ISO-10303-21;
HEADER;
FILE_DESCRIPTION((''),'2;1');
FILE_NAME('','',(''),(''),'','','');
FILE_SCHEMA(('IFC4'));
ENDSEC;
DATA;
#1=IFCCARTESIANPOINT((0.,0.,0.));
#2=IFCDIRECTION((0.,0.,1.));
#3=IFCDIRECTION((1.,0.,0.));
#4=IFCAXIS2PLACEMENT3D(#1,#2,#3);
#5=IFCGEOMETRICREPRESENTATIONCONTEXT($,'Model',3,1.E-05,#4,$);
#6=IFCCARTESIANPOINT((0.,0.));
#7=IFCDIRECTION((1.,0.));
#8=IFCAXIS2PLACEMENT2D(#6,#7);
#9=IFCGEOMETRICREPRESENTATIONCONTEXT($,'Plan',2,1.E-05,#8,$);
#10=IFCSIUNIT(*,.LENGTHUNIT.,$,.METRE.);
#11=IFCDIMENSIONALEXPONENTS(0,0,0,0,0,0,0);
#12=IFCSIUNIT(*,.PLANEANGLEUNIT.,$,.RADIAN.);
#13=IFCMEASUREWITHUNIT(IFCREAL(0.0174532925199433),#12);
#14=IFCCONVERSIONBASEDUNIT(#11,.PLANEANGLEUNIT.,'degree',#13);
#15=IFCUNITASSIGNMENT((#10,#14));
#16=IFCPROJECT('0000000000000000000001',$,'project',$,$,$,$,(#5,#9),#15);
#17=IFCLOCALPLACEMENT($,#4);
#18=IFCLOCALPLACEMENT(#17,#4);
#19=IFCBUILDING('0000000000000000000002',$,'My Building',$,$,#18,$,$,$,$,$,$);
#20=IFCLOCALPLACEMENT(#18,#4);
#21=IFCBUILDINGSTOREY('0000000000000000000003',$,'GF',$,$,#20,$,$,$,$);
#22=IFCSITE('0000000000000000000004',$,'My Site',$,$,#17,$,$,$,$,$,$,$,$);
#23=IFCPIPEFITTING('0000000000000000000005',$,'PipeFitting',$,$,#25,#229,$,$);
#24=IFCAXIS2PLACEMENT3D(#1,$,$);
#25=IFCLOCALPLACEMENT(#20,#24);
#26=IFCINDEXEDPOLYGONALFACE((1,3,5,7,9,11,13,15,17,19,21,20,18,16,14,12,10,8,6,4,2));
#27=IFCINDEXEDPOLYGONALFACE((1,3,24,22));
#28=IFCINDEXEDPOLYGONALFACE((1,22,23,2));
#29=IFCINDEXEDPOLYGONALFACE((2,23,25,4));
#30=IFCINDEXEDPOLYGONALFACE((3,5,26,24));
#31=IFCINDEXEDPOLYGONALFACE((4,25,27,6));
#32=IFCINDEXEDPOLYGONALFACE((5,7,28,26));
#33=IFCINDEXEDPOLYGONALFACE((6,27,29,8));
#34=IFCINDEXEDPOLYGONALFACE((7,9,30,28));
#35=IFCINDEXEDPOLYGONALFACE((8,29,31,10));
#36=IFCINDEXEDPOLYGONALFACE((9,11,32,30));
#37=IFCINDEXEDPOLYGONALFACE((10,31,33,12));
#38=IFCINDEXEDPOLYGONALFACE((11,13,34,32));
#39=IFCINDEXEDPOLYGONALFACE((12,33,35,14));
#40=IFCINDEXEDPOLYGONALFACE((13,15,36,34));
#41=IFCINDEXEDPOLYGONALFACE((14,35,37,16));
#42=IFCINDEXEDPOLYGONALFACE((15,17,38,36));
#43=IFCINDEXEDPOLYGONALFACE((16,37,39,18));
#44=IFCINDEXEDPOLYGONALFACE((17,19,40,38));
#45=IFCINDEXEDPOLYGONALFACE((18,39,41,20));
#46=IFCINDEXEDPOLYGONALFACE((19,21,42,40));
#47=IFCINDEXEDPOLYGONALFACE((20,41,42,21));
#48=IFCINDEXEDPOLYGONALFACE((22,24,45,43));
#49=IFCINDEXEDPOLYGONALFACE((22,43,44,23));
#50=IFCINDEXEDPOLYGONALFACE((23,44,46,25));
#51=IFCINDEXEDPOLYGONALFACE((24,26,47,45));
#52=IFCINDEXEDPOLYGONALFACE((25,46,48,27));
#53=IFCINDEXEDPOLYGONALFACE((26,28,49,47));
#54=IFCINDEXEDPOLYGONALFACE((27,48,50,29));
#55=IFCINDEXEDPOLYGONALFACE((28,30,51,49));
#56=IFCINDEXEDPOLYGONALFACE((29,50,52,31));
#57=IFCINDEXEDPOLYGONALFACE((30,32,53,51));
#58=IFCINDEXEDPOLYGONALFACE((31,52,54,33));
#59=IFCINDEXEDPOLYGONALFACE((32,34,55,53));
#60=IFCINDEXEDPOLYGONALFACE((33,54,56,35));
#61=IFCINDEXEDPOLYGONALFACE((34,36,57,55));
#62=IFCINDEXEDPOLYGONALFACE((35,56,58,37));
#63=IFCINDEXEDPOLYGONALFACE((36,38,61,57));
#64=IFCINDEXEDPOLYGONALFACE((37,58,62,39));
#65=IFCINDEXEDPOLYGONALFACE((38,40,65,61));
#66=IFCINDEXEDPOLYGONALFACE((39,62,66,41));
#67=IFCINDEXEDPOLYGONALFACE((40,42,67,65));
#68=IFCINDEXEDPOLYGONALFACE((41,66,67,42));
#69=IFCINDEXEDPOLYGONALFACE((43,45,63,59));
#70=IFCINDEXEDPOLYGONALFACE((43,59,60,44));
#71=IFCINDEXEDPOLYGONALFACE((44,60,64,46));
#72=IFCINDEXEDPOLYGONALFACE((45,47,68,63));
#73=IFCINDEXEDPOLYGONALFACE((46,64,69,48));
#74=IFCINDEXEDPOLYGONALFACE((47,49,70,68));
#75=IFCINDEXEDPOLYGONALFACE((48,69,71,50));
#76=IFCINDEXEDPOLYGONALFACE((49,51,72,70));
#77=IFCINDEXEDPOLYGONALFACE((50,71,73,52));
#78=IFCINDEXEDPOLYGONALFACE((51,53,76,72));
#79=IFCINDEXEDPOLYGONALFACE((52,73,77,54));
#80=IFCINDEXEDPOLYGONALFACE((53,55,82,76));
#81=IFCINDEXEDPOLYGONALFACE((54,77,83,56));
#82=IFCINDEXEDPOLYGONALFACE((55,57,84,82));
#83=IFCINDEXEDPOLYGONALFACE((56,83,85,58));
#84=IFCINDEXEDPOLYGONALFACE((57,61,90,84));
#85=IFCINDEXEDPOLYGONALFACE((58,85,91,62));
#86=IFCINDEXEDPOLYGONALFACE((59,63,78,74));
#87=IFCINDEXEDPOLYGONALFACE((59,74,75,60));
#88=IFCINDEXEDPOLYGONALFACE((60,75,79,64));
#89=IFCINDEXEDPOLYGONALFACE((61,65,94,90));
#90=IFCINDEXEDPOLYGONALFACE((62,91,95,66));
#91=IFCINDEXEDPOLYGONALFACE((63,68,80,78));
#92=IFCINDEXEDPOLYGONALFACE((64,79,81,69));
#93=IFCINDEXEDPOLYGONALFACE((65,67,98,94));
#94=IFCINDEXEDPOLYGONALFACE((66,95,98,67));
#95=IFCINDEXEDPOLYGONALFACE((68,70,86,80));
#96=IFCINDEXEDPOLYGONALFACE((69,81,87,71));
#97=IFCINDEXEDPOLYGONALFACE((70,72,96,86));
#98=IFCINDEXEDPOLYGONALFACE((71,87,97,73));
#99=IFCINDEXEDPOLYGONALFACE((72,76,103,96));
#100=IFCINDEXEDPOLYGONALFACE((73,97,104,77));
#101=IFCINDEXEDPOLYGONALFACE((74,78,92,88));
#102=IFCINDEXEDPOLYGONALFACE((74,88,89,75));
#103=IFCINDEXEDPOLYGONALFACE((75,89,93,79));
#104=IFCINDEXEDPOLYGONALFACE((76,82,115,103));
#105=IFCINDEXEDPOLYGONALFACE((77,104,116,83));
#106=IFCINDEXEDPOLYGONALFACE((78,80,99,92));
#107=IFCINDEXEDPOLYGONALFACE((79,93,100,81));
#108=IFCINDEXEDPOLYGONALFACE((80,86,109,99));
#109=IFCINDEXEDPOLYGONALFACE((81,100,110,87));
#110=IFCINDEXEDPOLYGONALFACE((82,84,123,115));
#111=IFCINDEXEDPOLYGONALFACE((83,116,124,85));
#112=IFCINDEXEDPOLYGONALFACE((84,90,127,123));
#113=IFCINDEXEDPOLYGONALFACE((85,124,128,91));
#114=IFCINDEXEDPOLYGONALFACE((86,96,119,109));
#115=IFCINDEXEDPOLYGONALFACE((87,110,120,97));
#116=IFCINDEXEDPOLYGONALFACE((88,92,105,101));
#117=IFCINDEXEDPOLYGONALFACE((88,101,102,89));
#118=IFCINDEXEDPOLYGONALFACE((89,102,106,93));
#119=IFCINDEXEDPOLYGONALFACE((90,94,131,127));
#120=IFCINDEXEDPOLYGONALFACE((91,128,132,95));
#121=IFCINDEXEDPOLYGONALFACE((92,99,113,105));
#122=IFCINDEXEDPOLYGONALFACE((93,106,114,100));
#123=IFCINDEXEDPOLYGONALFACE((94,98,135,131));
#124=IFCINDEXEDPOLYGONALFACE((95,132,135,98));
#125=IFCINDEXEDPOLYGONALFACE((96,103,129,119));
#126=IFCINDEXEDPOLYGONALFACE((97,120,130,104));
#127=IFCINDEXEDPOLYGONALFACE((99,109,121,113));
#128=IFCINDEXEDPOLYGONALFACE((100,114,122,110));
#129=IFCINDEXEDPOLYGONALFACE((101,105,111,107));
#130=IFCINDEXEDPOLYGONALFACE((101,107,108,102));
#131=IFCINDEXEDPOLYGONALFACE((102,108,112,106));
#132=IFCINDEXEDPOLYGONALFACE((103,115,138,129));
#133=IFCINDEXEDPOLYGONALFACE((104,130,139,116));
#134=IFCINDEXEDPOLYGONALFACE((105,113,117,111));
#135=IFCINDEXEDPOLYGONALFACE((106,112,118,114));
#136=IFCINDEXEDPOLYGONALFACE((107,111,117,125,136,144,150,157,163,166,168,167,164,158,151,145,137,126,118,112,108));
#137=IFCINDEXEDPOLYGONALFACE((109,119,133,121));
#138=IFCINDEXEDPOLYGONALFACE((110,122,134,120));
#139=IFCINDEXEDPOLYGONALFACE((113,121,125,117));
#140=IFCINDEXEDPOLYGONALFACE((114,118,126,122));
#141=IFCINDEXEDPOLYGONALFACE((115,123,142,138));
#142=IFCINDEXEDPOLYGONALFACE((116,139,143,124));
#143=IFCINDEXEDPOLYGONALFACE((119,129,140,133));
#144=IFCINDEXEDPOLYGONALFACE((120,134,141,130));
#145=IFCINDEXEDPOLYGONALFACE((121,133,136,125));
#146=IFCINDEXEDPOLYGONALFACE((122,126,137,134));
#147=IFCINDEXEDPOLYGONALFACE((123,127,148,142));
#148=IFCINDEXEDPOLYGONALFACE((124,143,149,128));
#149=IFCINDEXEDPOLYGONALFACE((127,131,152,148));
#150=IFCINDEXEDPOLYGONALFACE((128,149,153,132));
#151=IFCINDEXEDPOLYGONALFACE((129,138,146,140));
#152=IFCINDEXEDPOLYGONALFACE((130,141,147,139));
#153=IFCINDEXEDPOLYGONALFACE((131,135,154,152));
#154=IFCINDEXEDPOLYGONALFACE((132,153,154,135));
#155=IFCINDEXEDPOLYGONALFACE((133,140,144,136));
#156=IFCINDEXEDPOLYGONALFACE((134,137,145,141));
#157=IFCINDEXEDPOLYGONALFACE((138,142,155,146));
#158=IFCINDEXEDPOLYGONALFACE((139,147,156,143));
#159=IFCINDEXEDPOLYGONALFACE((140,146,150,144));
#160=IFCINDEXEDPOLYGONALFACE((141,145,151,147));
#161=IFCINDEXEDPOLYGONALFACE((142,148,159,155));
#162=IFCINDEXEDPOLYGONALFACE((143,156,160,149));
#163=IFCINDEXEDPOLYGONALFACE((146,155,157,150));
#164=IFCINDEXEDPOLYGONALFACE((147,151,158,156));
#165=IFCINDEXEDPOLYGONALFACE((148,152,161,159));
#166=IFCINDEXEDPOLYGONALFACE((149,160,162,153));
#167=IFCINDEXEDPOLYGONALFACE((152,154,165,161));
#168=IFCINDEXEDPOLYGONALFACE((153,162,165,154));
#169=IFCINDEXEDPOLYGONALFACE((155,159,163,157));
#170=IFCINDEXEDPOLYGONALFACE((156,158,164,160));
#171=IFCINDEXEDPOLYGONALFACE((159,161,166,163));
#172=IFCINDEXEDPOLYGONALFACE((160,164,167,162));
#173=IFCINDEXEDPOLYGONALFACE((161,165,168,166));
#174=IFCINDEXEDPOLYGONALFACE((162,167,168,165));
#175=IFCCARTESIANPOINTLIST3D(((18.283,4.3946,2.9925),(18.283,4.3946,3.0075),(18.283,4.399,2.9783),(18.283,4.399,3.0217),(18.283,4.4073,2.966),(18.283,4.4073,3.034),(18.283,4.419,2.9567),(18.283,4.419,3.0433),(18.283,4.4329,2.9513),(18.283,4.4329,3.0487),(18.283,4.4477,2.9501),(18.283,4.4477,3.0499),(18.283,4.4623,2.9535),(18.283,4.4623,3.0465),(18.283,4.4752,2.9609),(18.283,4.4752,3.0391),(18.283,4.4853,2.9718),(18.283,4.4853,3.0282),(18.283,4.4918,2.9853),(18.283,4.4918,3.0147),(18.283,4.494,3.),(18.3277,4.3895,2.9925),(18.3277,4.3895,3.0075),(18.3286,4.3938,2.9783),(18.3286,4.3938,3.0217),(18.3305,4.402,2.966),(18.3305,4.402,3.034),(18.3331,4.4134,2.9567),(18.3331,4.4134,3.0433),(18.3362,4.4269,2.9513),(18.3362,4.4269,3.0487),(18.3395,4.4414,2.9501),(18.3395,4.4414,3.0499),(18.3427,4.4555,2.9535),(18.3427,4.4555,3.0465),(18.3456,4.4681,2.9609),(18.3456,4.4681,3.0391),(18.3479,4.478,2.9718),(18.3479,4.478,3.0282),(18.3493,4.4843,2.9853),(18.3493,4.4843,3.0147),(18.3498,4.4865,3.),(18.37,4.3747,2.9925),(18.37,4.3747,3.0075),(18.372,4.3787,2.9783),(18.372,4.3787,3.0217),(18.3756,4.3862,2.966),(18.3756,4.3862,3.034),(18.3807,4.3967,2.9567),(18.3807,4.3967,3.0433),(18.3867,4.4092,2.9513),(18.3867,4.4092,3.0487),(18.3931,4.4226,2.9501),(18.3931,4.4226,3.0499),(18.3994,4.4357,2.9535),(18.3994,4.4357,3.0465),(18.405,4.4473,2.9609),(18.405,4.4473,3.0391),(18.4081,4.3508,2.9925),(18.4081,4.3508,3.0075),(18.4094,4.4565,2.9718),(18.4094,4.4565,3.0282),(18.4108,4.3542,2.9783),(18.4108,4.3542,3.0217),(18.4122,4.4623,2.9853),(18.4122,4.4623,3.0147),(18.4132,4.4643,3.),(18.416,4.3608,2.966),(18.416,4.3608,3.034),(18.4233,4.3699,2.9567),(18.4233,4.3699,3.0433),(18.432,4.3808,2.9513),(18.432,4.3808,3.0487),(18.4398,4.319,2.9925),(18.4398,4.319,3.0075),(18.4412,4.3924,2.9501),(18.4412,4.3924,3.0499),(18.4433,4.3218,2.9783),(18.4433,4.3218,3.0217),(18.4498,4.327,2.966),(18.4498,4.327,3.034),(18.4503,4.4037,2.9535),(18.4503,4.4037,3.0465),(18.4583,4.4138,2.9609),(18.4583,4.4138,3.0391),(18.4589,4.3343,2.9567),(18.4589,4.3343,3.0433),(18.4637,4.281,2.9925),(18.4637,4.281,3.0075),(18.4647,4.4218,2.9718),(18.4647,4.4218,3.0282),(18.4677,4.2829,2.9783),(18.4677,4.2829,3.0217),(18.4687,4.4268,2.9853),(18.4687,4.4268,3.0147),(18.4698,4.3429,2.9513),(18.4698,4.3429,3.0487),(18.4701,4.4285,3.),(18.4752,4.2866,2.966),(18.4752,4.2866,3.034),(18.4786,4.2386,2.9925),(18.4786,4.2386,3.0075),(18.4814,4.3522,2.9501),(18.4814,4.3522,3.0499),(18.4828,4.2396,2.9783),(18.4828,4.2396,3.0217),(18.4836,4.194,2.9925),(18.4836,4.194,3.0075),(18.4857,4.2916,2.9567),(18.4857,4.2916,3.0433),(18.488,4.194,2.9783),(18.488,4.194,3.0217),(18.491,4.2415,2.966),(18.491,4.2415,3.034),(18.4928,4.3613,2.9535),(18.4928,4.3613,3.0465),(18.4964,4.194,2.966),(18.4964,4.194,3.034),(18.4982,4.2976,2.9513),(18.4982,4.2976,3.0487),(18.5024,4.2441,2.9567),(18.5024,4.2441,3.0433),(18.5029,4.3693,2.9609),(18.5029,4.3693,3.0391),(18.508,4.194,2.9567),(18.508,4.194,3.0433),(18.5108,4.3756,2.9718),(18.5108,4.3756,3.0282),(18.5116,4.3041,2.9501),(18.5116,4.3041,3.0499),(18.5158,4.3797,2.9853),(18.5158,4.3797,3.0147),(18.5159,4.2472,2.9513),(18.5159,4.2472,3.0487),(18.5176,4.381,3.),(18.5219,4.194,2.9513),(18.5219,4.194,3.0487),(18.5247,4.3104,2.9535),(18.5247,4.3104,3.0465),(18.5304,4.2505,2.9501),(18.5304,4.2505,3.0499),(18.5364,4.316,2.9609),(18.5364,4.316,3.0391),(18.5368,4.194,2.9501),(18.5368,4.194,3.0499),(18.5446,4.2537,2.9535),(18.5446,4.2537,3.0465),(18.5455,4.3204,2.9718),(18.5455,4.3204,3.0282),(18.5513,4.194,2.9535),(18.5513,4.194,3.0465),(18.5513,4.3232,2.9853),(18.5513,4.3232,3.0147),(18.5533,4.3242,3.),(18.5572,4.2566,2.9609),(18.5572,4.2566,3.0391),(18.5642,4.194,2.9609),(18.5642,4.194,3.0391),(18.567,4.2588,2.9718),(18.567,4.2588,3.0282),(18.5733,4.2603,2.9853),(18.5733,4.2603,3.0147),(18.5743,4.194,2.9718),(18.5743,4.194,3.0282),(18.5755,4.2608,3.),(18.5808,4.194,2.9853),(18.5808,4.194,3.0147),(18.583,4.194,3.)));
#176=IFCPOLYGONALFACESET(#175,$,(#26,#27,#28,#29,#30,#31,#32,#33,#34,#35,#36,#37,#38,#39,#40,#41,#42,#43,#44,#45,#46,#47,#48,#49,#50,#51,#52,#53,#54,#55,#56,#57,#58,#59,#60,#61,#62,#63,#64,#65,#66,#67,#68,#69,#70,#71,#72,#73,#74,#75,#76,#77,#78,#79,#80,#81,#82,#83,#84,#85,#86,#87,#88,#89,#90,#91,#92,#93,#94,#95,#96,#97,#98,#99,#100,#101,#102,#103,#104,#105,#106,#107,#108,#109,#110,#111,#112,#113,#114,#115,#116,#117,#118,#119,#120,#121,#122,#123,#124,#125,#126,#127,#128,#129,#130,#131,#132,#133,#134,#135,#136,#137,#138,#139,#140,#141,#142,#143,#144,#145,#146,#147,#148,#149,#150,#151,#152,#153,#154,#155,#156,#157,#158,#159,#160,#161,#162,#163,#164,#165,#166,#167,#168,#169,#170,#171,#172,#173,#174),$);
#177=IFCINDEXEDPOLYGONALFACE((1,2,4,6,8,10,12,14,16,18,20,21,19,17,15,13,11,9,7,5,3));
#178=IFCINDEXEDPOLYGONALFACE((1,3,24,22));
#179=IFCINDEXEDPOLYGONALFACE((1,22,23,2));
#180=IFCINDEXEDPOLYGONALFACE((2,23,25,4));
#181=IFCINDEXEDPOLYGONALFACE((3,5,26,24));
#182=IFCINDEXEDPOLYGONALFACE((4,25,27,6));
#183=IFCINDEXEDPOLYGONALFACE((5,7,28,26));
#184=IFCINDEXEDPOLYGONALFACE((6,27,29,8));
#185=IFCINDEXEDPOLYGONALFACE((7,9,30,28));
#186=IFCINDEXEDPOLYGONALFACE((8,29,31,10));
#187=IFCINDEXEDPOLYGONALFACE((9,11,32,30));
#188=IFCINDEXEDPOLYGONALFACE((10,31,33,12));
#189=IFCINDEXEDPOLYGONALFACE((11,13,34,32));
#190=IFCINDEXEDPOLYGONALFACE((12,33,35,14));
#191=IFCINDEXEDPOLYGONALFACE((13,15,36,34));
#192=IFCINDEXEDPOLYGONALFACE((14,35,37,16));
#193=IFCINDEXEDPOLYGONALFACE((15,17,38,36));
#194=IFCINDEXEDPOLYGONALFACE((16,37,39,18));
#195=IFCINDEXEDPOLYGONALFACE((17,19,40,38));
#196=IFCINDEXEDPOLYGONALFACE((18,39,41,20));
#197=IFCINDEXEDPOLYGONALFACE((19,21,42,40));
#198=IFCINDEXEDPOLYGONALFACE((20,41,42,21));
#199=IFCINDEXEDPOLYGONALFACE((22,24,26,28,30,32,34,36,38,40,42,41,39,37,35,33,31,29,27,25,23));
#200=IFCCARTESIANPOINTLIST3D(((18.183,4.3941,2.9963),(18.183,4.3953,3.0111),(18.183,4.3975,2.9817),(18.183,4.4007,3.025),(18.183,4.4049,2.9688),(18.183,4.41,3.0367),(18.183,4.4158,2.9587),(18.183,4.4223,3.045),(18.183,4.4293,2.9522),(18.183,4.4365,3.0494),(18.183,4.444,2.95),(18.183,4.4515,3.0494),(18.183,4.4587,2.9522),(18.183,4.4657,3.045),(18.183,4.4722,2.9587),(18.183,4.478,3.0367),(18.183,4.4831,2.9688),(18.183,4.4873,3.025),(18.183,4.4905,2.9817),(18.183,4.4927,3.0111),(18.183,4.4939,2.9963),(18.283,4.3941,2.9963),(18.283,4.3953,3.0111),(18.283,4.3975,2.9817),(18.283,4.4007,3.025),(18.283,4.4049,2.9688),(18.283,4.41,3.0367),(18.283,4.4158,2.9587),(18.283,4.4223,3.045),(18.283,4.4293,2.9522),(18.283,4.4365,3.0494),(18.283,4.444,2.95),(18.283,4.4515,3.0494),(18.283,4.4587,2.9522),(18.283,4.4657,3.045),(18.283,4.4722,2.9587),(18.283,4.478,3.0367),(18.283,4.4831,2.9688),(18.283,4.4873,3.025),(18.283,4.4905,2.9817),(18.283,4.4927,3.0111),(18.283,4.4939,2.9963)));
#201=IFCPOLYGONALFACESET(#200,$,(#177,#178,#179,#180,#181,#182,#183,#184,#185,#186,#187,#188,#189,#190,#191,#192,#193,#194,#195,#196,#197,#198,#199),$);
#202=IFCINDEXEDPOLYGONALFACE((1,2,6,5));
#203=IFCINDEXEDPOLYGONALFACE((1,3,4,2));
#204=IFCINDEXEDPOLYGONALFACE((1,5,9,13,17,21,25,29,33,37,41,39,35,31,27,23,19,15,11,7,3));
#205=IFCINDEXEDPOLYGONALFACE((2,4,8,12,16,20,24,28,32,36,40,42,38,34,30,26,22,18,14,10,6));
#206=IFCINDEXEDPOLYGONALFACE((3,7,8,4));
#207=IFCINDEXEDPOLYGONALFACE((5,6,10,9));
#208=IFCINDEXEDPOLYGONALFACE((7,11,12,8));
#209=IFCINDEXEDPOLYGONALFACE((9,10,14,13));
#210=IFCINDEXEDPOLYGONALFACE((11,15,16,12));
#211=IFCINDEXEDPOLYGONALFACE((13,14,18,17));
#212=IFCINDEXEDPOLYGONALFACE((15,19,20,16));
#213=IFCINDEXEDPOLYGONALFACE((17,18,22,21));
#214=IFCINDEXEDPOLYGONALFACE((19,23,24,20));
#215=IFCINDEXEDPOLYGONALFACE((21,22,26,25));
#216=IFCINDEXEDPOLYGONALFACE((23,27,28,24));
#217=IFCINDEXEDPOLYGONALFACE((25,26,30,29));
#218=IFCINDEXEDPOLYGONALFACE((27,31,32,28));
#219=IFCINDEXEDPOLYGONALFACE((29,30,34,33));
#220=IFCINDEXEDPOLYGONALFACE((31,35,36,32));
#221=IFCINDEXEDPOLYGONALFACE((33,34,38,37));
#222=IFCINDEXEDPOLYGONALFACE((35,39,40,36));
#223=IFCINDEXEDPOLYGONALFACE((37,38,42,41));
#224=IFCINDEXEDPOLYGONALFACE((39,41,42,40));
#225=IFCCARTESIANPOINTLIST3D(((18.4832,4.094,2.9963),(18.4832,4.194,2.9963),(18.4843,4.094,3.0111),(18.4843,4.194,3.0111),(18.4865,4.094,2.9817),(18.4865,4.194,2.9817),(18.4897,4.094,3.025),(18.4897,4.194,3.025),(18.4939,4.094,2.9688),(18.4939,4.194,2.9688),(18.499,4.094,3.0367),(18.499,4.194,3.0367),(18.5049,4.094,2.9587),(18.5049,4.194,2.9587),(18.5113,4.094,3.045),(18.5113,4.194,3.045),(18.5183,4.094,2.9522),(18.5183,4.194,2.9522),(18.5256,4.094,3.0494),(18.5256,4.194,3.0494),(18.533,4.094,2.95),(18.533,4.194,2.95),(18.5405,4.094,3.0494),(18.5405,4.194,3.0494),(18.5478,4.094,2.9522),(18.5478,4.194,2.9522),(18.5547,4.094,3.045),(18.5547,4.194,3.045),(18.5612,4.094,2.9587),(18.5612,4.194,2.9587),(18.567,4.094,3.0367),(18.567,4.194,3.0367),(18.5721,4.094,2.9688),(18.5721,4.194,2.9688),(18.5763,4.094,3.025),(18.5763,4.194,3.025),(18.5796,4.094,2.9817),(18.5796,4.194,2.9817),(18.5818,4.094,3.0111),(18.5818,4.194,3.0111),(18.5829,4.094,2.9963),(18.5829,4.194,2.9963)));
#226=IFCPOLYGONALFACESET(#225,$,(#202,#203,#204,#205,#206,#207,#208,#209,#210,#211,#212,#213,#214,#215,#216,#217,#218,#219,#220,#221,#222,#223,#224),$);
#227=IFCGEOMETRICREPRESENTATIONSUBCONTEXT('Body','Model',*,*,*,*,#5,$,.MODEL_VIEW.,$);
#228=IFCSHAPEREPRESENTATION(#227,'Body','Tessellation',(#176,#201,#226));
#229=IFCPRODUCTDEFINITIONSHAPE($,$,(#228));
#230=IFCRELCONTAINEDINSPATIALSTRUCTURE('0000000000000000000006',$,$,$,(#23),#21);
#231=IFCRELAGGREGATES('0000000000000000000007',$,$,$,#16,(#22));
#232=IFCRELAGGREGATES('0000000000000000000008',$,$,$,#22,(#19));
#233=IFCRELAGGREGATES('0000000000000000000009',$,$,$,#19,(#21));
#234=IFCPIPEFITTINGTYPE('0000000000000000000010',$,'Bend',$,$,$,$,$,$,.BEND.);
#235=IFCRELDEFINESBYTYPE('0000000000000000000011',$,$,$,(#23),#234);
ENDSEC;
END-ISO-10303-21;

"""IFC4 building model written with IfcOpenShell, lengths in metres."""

from ifc_helpers import new_model, entity, si_unit, converted_unit, frame, origin_with_axes, origin_2d_with_axis, place, context, subcontext, project, spatial, circle, extrude, source, transform, mapped, type_object, type_shapes, element, save


model = new_model("IFC4")

# Units and contexts
model_context = context("Model", 3, precision=1e-05, world=origin_with_axes())
plan_context = context("Plan", 2, precision=1e-05, world=origin_2d_with_axis())
body_context_1 = subcontext(model_context, "Body", "Model", "MODEL_VIEW")
ifc_project = project(units=[si_unit("LENGTHUNIT", "METRE"), converted_unit("PLANEANGLEUNIT", "degree", entity("IfcReal", 0.0174532925199433), si_unit("PLANEANGLEUNIT", "RADIAN"), dimensions=[0, 0, 0, 0, 0, 0, 0])], contexts=[model_context, plan_context])

# Site, building, storey
site_placement = place(None, origin_with_axes())
site = spatial("IfcSite", under=ifc_project, at=site_placement, Name="My Site")
building_placement = place(site_placement, origin_with_axes())
building = spatial("IfcBuilding", under=site, at=building_placement, Name="My Building")
storey_placement = place(building_placement, origin_with_axes())
storey = spatial("IfcBuildingStorey", under=building, at=storey_placement, Name="GF")

# Pipe fitting
pipe_fitting_type = type_object("IfcPipeFittingType", Name="Bend", PredefinedType="BEND")
shared_shape_1 = source(origin_with_axes(), body_context_1, "Body", "SolidModel", [
    entity("IfcSweptDiskSolid", entity("IfcIndexedPolyCurve", entity("IfcCartesianPointList3D", [[0.0, 0.0, 0.1], [0.0, -0.0732, 0.2768], [0.0, -0.25, 0.35]]), [entity("IfcArcIndex", [1, 2, 3])]), 0.05),
    extrude(circle(Radius=0.05), origin_with_axes(), (0.0, 0.0, 1.0), 0.1),
    extrude(circle(Radius=0.05), frame((0.0, -0.25, 0.35), z_axis=(0.0, -1.0, 0.0), x_axis=(1.0, 0.0, 0.0)), (0.0, 0.0, 1.0), 0.1),
])
type_shapes(pipe_fitting_type, [shared_shape_1])
for number, where, z_axis, x_axis, name in (
    (1, (18.183, 4.444, 3.0), (1.0, 0.0, 0.0), (0.0, 0.0, -1.0), "PipeFitting"),
):
    element("IfcPipeFitting", number, at=place(storey_placement, frame(where, z_axis=z_axis, x_axis=x_axis)), inside=storey, type_object=pipe_fitting_type, Name=name, context=body_context_1, shape_type="MappedRepresentation", body=[
        mapped(shared_shape_1, transform((0.0, 0.0, 0.0), x_axis=(1.0, 0.0, 0.0), y_axis=(0.0, 1.0, 0.0), z_axis=(0.0, 0.0, 1.0), scale=1.0)),
    ])

save(model, "model.ifc")
